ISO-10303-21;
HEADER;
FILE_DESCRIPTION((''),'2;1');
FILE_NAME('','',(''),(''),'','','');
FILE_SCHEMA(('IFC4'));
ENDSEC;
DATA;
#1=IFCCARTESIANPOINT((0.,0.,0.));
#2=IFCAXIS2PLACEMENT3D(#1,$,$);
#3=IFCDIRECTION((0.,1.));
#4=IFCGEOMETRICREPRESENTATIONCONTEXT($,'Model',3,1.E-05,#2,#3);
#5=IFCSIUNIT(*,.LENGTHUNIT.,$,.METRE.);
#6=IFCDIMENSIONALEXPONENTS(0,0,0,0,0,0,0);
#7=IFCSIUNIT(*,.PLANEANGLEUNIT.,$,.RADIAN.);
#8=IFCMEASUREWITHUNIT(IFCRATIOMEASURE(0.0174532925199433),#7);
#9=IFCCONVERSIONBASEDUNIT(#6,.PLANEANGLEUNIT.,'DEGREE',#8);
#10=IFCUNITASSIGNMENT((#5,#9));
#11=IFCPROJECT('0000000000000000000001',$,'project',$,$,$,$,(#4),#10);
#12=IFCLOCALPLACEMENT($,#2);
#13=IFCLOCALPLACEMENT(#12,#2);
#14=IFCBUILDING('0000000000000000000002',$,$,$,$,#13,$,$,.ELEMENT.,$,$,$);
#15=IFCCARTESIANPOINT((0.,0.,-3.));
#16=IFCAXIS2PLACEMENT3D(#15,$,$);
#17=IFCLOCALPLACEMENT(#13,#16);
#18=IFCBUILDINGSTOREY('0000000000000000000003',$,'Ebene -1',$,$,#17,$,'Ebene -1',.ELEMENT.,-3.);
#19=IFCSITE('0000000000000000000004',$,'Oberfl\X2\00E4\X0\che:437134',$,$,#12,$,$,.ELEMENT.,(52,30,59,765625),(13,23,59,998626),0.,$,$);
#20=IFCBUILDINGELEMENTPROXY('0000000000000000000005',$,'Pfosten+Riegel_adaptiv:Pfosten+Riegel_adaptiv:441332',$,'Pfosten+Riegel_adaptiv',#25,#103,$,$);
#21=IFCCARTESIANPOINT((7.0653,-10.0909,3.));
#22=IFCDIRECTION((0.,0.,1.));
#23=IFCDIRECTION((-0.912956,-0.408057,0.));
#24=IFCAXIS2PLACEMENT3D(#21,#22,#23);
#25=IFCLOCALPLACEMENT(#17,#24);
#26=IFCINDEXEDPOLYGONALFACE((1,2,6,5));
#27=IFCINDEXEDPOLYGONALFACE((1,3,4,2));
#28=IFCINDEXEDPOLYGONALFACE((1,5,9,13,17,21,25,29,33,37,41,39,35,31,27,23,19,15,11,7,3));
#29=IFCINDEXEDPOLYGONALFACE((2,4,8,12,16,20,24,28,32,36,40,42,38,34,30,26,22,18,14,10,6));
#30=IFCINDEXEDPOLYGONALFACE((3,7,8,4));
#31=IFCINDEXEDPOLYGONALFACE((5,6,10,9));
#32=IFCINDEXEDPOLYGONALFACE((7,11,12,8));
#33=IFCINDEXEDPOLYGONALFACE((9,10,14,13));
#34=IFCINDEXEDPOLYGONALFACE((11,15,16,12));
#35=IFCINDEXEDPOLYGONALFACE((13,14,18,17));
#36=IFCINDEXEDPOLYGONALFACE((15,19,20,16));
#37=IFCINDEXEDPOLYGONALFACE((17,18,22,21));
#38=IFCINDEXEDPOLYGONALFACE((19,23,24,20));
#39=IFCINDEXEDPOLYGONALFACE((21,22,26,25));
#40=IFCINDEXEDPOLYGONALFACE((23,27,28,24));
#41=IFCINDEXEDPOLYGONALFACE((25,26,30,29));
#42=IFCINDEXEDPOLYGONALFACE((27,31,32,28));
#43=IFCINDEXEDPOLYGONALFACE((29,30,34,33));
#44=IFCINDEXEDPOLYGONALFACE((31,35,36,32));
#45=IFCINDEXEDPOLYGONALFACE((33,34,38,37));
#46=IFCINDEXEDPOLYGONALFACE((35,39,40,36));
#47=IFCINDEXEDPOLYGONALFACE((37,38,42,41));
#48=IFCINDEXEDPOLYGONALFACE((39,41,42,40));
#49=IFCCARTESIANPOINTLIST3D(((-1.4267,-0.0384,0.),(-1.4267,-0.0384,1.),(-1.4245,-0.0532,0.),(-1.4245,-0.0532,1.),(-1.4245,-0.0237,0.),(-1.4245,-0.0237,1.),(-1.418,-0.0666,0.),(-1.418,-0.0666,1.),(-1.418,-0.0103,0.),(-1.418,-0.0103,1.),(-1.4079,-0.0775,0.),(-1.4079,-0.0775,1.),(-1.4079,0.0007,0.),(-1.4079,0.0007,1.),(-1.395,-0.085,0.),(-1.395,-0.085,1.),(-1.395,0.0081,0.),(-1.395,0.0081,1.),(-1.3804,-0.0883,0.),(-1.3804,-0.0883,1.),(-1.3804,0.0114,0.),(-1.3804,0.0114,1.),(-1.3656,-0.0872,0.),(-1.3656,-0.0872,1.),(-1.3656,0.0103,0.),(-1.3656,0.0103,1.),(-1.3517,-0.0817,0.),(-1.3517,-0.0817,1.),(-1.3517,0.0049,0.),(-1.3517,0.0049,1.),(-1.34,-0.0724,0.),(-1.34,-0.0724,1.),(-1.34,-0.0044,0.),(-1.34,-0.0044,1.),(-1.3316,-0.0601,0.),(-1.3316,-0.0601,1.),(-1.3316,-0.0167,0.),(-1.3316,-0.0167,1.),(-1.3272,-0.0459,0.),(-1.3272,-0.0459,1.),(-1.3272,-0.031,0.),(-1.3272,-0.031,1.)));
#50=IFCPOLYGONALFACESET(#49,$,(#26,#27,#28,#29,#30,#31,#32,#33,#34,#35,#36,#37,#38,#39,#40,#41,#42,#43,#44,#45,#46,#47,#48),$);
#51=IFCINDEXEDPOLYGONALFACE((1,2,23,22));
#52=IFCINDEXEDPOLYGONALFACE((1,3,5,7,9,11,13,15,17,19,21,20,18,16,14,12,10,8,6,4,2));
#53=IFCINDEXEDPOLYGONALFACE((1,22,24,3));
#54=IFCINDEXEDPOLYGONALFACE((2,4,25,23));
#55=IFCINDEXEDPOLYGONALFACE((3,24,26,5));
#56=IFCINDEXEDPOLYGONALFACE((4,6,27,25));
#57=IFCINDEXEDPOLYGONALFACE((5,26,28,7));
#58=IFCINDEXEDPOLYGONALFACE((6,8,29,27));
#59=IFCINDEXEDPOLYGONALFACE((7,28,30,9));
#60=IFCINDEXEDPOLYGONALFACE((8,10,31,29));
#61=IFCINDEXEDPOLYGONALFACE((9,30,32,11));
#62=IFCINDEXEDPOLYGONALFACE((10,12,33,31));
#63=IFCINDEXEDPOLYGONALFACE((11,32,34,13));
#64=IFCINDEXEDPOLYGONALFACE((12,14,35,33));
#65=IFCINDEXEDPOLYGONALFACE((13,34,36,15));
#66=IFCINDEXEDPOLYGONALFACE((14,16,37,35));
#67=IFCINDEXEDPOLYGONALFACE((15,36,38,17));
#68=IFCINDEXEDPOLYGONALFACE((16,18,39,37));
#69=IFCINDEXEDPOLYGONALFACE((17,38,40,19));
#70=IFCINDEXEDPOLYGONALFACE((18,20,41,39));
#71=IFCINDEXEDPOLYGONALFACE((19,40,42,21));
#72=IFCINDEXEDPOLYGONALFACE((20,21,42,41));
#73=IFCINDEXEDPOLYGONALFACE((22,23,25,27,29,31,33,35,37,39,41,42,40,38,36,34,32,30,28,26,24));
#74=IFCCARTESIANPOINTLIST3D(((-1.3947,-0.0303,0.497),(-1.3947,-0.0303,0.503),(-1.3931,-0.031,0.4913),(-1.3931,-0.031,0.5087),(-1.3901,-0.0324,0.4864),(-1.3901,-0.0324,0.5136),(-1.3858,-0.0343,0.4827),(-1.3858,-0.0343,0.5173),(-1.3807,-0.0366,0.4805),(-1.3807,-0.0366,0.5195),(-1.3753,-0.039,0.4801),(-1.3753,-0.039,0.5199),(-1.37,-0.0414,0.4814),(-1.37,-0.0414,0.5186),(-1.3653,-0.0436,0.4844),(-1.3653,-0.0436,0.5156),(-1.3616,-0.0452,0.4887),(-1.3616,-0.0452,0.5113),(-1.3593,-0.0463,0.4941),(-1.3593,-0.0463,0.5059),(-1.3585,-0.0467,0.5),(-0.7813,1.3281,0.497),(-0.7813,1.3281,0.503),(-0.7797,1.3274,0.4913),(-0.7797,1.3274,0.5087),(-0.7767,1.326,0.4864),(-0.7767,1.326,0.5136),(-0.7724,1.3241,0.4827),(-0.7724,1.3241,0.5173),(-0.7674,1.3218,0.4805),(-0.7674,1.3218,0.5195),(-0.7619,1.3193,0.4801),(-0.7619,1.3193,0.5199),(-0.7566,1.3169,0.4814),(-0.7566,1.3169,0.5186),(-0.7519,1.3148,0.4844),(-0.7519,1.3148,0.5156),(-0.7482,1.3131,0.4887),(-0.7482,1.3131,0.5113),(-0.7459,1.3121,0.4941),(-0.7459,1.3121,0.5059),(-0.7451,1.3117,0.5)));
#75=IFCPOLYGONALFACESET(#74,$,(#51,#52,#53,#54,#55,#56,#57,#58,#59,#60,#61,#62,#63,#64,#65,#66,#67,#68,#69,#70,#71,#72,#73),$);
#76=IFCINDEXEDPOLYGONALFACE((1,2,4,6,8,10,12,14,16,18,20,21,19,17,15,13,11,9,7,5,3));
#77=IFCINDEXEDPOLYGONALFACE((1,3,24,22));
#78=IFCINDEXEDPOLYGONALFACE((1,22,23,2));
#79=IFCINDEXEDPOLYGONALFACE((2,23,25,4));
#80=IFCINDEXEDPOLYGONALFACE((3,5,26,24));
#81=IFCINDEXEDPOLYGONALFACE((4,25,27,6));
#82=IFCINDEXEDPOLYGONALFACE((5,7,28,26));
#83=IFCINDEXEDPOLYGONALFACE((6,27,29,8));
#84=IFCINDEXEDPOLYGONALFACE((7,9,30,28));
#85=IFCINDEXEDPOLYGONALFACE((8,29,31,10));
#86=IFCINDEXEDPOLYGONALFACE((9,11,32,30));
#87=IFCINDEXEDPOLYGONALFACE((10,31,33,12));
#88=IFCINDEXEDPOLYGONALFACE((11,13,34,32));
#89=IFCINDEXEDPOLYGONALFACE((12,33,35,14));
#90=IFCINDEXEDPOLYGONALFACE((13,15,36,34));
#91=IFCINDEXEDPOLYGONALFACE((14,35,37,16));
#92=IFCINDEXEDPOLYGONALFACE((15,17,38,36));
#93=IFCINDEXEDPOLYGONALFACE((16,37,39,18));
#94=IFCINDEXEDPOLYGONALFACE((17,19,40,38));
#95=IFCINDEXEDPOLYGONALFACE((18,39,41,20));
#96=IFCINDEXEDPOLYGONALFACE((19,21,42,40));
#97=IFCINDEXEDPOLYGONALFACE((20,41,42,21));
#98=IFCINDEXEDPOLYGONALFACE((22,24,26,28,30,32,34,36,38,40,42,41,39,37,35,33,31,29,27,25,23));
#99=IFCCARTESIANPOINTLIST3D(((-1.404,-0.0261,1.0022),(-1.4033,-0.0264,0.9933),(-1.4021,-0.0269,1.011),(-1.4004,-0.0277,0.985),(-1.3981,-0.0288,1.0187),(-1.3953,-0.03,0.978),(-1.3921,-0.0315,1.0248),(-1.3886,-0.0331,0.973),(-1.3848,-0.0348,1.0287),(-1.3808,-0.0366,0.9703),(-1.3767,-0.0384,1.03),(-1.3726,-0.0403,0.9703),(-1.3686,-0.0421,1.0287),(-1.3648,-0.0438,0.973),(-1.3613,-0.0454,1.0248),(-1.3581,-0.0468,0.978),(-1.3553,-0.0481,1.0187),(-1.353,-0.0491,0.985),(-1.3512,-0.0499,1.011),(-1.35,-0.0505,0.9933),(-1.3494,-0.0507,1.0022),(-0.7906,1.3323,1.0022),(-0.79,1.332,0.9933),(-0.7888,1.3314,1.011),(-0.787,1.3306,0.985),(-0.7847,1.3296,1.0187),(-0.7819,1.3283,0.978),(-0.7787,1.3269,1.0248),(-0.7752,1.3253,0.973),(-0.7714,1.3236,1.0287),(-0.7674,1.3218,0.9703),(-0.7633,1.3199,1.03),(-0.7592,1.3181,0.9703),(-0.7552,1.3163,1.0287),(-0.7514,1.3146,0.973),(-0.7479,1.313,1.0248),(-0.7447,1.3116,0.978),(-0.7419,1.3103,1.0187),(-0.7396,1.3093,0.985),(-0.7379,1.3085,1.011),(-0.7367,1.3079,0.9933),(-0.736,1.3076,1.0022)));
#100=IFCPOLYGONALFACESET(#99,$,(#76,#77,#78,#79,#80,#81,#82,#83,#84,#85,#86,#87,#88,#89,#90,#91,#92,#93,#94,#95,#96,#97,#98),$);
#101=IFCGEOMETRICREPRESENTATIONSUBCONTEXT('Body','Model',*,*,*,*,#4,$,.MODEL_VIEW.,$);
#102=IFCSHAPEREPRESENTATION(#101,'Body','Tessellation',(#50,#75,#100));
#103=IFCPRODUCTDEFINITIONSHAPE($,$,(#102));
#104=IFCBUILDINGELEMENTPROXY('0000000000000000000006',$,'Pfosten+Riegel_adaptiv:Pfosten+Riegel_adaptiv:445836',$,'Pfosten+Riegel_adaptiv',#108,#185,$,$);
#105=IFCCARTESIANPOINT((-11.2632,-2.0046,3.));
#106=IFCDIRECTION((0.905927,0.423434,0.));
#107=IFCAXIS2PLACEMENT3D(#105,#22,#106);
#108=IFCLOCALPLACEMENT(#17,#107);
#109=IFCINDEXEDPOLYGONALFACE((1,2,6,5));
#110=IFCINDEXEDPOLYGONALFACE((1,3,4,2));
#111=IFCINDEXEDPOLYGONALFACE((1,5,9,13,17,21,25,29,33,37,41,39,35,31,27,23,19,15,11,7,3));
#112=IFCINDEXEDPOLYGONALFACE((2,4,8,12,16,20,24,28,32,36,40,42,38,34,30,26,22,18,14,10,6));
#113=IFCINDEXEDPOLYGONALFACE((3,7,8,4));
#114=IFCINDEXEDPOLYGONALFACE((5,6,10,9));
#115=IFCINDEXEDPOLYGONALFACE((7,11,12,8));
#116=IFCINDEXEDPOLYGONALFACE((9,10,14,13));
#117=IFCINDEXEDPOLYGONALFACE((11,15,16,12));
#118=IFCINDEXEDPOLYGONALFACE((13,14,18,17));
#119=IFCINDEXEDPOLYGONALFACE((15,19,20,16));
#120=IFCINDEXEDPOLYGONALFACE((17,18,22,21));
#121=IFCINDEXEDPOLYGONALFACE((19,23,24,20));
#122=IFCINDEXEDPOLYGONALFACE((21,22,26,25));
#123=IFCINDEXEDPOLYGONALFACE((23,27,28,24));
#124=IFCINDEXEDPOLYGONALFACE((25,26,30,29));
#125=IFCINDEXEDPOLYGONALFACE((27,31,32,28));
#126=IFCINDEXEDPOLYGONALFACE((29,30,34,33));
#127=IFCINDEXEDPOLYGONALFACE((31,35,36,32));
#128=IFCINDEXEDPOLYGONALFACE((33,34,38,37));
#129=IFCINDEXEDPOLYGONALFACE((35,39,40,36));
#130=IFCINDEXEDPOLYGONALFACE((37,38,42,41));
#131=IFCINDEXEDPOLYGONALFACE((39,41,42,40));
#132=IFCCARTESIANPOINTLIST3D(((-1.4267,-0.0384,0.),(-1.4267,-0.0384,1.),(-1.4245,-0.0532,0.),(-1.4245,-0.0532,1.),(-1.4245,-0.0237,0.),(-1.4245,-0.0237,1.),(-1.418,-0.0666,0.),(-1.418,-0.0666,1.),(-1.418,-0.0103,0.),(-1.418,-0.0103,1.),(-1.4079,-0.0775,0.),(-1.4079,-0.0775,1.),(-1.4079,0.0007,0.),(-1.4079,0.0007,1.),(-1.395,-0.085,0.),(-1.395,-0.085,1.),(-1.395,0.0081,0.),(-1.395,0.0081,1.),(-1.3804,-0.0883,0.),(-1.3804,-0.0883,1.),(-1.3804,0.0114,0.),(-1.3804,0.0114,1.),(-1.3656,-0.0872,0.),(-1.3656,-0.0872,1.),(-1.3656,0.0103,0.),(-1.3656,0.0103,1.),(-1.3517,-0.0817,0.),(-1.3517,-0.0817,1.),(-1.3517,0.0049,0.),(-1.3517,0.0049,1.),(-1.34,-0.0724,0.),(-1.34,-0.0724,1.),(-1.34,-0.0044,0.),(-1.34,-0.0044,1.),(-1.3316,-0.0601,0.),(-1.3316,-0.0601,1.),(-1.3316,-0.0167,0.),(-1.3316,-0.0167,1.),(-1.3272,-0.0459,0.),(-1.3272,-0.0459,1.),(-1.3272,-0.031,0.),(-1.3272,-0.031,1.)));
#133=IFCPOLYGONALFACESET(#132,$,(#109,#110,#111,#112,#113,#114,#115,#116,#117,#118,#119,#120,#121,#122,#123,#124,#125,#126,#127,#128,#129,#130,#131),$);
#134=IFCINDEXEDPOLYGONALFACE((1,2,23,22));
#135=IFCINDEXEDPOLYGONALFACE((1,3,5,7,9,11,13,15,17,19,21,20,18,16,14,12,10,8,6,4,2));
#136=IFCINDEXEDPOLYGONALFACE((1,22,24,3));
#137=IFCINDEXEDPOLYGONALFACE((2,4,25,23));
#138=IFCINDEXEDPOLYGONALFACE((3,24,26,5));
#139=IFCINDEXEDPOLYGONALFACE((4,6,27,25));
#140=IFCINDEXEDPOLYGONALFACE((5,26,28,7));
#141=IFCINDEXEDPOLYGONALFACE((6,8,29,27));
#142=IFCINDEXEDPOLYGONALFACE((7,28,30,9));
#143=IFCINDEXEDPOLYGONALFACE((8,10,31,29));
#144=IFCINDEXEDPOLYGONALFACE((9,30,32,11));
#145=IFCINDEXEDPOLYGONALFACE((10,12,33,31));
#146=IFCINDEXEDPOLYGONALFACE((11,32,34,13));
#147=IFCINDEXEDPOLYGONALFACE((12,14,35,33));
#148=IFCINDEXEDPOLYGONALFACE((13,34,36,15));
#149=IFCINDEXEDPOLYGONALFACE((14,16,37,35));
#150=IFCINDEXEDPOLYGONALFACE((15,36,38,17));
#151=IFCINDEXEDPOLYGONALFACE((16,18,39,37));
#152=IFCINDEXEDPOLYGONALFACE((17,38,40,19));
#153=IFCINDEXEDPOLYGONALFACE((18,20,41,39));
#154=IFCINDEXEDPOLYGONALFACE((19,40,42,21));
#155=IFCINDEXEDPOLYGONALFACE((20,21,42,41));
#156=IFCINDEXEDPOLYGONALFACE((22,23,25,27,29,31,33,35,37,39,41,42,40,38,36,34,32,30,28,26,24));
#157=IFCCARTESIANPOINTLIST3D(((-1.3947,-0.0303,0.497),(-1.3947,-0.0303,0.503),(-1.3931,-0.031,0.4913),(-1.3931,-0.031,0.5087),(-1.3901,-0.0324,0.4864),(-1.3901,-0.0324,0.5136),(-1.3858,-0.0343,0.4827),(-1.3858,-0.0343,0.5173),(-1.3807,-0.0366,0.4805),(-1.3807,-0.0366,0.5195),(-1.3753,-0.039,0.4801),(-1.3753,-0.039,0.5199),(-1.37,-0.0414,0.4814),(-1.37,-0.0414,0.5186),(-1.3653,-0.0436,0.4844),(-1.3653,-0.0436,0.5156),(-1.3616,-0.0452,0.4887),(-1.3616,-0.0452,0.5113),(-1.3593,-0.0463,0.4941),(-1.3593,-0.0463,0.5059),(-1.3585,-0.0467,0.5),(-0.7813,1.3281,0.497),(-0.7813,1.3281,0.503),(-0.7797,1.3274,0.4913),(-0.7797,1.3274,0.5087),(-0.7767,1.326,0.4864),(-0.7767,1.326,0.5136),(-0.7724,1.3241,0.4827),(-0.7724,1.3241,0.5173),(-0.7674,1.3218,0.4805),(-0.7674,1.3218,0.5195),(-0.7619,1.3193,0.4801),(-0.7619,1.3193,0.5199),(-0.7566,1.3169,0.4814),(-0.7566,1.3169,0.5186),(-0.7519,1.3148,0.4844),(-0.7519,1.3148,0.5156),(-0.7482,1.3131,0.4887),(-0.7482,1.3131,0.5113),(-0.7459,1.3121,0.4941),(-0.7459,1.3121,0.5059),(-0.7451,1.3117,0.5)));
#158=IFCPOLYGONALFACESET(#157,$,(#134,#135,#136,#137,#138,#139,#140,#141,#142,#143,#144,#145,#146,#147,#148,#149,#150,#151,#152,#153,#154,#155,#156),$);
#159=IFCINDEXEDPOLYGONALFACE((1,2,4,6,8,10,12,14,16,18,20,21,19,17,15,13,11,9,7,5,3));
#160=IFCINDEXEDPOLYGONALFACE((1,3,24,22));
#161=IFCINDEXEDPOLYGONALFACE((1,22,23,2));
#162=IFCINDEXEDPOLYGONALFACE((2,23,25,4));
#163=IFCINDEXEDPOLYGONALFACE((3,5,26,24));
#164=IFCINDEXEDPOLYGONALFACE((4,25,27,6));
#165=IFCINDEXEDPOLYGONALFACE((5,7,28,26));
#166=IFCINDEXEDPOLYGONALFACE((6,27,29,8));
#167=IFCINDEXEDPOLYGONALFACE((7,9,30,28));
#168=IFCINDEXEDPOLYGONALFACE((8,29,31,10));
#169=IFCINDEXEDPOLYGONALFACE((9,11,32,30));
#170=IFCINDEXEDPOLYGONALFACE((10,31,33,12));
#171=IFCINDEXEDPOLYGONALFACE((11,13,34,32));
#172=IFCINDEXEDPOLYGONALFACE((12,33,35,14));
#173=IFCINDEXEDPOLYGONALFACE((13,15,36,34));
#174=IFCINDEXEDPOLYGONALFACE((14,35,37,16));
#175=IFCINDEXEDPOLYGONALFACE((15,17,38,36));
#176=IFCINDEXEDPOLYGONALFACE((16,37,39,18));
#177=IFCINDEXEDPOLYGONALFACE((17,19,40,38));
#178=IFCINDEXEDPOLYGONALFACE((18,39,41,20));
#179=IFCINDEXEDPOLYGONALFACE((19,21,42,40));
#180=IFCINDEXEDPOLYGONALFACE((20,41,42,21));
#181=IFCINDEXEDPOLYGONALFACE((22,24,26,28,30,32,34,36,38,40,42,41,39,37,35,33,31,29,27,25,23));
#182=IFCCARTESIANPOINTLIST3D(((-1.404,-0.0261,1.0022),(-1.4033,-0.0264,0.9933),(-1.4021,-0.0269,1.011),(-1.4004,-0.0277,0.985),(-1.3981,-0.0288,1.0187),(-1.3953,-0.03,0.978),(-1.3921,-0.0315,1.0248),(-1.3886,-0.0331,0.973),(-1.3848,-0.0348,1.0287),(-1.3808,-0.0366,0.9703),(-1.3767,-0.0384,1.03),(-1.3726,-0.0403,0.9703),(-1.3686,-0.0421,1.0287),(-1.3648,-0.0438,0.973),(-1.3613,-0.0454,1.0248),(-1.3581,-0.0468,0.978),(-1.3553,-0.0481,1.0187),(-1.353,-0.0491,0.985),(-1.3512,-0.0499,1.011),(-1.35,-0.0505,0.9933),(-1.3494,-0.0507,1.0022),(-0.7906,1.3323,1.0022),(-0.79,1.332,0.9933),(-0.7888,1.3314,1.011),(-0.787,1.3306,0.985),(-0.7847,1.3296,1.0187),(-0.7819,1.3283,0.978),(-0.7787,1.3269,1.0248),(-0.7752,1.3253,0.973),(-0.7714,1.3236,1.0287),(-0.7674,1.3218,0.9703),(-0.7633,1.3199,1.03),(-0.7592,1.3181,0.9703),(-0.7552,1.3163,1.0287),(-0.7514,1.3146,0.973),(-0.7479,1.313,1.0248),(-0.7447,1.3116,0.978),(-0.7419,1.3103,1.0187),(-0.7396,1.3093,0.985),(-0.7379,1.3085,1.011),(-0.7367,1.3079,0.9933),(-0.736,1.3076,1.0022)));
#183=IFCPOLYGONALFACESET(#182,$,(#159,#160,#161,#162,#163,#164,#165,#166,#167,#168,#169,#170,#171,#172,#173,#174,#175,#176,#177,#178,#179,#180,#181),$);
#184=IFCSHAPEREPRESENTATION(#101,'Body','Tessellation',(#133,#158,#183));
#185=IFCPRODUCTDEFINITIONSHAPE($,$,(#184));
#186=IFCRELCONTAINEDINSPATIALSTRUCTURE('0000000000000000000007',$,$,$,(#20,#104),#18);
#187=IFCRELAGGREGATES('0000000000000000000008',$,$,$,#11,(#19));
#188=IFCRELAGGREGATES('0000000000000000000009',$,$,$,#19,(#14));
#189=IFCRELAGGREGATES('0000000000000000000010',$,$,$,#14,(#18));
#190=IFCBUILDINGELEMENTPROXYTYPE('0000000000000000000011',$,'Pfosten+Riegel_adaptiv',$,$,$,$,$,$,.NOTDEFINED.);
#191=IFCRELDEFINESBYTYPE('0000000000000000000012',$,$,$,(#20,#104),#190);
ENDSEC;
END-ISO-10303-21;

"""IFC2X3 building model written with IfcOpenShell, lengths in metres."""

from ifc_helpers import new_model, entity, si_unit, converted_unit, direction, frame, frame_2d, origin, place, context, subcontext, project, spatial, circle, extrude, source, transform, mapped, type_object, type_shapes, element, save


model = new_model("IFC2X3")

# Units and contexts
model_context = context("Model", 3, precision=1e-05, world=origin(), true_north=direction((0.0, 1.0)))
body_context = subcontext(model_context, "Body", "Model", "MODEL_VIEW")
ifc_project = project(units=[si_unit("LENGTHUNIT", "METRE"), converted_unit("PLANEANGLEUNIT", "DEGREE", entity("IfcRatioMeasure", 0.0174532925199433), si_unit("PLANEANGLEUNIT", "RADIAN"), dimensions=[0, 0, 0, 0, 0, 0, 0])], contexts=[model_context])

# Site, building, storey
site_placement = place(None, origin())
site = spatial("IfcSite", under=ifc_project, at=site_placement, Name="Oberfläche:437134", CompositionType="ELEMENT", RefLatitude=(52, 30, 59, 765625), RefLongitude=(13, 23, 59, 998626), RefElevation=0.0)
building_placement = place(site_placement, origin())
building = spatial("IfcBuilding", under=site, at=building_placement, CompositionType="ELEMENT")
storey_placement = place(building_placement, frame((0.0, 0.0, -3.0)))
storey = spatial("IfcBuildingStorey", under=building, at=storey_placement, Name="Ebene -1", LongName="Ebene -1", CompositionType="ELEMENT", Elevation=-3.0)

# Building element proxies
building_element_proxy_type_1 = type_object("IfcBuildingElementProxyType", Name="Pfosten+Riegel_adaptiv", PredefinedType="NOTDEFINED")
shared_shape_1 = source(origin(), body_context, "Body", "SweptSolid", [
    extrude(circle(Radius=0.05, at=frame_2d((0.0, 0.0), x_axis=(1.0, 0.0))), frame((-1.3767, -0.0384, 0.0), z_axis=(0.0, 0.0, 1.0), x_axis=(-1.0, 0.0, 0.0)), (0.0, 0.0, 1.0), 1.0),
    extrude(circle(Radius=0.02, at=frame_2d((0.0, 0.0), x_axis=(1.0, 0.0))), frame((-1.3767, -0.0384, 0.5), z_axis=(0.411546, 0.911389, 0.0), x_axis=(0.911389, -0.411546, 0.0)), (0.0, 0.0, 1.0), 1.4904),
    extrude(circle(Radius=0.03, at=frame_2d((0.0, 0.0), x_axis=(1.0, 0.0))), frame((-1.3767, -0.0384, 1.0), z_axis=(0.411546, 0.911389, 0.0), x_axis=(0.0, 0.0, 1.0)), (0.0, 0.0, 1.0), 1.4904),
])
type_shapes(building_element_proxy_type_1, [shared_shape_1])
for number, where, z_axis, x_axis, name in (
    (1, (7.0653, -10.0909, 3.0), (0.0, 0.0, 1.0), (-0.912956, -0.408057, 0.0), "Pfosten+Riegel_adaptiv:Pfosten+Riegel_adaptiv:441332"),
    (2, (-11.2632, -2.0046, 3.0), (0.0, 0.0, 1.0), (0.905927, 0.423434, 0.0), "Pfosten+Riegel_adaptiv:Pfosten+Riegel_adaptiv:445836"),
):
    element("IfcBuildingElementProxy", number, at=place(storey_placement, frame(where, z_axis=z_axis, x_axis=x_axis)), inside=storey, type_object=building_element_proxy_type_1, Name=name, ObjectType="Pfosten+Riegel_adaptiv", context=body_context, shape_type="MappedRepresentation", body=[
        mapped(shared_shape_1, transform((0.0, 0.0, 0.0), scale=1.0)),
    ])

save(model, "model.ifc")
